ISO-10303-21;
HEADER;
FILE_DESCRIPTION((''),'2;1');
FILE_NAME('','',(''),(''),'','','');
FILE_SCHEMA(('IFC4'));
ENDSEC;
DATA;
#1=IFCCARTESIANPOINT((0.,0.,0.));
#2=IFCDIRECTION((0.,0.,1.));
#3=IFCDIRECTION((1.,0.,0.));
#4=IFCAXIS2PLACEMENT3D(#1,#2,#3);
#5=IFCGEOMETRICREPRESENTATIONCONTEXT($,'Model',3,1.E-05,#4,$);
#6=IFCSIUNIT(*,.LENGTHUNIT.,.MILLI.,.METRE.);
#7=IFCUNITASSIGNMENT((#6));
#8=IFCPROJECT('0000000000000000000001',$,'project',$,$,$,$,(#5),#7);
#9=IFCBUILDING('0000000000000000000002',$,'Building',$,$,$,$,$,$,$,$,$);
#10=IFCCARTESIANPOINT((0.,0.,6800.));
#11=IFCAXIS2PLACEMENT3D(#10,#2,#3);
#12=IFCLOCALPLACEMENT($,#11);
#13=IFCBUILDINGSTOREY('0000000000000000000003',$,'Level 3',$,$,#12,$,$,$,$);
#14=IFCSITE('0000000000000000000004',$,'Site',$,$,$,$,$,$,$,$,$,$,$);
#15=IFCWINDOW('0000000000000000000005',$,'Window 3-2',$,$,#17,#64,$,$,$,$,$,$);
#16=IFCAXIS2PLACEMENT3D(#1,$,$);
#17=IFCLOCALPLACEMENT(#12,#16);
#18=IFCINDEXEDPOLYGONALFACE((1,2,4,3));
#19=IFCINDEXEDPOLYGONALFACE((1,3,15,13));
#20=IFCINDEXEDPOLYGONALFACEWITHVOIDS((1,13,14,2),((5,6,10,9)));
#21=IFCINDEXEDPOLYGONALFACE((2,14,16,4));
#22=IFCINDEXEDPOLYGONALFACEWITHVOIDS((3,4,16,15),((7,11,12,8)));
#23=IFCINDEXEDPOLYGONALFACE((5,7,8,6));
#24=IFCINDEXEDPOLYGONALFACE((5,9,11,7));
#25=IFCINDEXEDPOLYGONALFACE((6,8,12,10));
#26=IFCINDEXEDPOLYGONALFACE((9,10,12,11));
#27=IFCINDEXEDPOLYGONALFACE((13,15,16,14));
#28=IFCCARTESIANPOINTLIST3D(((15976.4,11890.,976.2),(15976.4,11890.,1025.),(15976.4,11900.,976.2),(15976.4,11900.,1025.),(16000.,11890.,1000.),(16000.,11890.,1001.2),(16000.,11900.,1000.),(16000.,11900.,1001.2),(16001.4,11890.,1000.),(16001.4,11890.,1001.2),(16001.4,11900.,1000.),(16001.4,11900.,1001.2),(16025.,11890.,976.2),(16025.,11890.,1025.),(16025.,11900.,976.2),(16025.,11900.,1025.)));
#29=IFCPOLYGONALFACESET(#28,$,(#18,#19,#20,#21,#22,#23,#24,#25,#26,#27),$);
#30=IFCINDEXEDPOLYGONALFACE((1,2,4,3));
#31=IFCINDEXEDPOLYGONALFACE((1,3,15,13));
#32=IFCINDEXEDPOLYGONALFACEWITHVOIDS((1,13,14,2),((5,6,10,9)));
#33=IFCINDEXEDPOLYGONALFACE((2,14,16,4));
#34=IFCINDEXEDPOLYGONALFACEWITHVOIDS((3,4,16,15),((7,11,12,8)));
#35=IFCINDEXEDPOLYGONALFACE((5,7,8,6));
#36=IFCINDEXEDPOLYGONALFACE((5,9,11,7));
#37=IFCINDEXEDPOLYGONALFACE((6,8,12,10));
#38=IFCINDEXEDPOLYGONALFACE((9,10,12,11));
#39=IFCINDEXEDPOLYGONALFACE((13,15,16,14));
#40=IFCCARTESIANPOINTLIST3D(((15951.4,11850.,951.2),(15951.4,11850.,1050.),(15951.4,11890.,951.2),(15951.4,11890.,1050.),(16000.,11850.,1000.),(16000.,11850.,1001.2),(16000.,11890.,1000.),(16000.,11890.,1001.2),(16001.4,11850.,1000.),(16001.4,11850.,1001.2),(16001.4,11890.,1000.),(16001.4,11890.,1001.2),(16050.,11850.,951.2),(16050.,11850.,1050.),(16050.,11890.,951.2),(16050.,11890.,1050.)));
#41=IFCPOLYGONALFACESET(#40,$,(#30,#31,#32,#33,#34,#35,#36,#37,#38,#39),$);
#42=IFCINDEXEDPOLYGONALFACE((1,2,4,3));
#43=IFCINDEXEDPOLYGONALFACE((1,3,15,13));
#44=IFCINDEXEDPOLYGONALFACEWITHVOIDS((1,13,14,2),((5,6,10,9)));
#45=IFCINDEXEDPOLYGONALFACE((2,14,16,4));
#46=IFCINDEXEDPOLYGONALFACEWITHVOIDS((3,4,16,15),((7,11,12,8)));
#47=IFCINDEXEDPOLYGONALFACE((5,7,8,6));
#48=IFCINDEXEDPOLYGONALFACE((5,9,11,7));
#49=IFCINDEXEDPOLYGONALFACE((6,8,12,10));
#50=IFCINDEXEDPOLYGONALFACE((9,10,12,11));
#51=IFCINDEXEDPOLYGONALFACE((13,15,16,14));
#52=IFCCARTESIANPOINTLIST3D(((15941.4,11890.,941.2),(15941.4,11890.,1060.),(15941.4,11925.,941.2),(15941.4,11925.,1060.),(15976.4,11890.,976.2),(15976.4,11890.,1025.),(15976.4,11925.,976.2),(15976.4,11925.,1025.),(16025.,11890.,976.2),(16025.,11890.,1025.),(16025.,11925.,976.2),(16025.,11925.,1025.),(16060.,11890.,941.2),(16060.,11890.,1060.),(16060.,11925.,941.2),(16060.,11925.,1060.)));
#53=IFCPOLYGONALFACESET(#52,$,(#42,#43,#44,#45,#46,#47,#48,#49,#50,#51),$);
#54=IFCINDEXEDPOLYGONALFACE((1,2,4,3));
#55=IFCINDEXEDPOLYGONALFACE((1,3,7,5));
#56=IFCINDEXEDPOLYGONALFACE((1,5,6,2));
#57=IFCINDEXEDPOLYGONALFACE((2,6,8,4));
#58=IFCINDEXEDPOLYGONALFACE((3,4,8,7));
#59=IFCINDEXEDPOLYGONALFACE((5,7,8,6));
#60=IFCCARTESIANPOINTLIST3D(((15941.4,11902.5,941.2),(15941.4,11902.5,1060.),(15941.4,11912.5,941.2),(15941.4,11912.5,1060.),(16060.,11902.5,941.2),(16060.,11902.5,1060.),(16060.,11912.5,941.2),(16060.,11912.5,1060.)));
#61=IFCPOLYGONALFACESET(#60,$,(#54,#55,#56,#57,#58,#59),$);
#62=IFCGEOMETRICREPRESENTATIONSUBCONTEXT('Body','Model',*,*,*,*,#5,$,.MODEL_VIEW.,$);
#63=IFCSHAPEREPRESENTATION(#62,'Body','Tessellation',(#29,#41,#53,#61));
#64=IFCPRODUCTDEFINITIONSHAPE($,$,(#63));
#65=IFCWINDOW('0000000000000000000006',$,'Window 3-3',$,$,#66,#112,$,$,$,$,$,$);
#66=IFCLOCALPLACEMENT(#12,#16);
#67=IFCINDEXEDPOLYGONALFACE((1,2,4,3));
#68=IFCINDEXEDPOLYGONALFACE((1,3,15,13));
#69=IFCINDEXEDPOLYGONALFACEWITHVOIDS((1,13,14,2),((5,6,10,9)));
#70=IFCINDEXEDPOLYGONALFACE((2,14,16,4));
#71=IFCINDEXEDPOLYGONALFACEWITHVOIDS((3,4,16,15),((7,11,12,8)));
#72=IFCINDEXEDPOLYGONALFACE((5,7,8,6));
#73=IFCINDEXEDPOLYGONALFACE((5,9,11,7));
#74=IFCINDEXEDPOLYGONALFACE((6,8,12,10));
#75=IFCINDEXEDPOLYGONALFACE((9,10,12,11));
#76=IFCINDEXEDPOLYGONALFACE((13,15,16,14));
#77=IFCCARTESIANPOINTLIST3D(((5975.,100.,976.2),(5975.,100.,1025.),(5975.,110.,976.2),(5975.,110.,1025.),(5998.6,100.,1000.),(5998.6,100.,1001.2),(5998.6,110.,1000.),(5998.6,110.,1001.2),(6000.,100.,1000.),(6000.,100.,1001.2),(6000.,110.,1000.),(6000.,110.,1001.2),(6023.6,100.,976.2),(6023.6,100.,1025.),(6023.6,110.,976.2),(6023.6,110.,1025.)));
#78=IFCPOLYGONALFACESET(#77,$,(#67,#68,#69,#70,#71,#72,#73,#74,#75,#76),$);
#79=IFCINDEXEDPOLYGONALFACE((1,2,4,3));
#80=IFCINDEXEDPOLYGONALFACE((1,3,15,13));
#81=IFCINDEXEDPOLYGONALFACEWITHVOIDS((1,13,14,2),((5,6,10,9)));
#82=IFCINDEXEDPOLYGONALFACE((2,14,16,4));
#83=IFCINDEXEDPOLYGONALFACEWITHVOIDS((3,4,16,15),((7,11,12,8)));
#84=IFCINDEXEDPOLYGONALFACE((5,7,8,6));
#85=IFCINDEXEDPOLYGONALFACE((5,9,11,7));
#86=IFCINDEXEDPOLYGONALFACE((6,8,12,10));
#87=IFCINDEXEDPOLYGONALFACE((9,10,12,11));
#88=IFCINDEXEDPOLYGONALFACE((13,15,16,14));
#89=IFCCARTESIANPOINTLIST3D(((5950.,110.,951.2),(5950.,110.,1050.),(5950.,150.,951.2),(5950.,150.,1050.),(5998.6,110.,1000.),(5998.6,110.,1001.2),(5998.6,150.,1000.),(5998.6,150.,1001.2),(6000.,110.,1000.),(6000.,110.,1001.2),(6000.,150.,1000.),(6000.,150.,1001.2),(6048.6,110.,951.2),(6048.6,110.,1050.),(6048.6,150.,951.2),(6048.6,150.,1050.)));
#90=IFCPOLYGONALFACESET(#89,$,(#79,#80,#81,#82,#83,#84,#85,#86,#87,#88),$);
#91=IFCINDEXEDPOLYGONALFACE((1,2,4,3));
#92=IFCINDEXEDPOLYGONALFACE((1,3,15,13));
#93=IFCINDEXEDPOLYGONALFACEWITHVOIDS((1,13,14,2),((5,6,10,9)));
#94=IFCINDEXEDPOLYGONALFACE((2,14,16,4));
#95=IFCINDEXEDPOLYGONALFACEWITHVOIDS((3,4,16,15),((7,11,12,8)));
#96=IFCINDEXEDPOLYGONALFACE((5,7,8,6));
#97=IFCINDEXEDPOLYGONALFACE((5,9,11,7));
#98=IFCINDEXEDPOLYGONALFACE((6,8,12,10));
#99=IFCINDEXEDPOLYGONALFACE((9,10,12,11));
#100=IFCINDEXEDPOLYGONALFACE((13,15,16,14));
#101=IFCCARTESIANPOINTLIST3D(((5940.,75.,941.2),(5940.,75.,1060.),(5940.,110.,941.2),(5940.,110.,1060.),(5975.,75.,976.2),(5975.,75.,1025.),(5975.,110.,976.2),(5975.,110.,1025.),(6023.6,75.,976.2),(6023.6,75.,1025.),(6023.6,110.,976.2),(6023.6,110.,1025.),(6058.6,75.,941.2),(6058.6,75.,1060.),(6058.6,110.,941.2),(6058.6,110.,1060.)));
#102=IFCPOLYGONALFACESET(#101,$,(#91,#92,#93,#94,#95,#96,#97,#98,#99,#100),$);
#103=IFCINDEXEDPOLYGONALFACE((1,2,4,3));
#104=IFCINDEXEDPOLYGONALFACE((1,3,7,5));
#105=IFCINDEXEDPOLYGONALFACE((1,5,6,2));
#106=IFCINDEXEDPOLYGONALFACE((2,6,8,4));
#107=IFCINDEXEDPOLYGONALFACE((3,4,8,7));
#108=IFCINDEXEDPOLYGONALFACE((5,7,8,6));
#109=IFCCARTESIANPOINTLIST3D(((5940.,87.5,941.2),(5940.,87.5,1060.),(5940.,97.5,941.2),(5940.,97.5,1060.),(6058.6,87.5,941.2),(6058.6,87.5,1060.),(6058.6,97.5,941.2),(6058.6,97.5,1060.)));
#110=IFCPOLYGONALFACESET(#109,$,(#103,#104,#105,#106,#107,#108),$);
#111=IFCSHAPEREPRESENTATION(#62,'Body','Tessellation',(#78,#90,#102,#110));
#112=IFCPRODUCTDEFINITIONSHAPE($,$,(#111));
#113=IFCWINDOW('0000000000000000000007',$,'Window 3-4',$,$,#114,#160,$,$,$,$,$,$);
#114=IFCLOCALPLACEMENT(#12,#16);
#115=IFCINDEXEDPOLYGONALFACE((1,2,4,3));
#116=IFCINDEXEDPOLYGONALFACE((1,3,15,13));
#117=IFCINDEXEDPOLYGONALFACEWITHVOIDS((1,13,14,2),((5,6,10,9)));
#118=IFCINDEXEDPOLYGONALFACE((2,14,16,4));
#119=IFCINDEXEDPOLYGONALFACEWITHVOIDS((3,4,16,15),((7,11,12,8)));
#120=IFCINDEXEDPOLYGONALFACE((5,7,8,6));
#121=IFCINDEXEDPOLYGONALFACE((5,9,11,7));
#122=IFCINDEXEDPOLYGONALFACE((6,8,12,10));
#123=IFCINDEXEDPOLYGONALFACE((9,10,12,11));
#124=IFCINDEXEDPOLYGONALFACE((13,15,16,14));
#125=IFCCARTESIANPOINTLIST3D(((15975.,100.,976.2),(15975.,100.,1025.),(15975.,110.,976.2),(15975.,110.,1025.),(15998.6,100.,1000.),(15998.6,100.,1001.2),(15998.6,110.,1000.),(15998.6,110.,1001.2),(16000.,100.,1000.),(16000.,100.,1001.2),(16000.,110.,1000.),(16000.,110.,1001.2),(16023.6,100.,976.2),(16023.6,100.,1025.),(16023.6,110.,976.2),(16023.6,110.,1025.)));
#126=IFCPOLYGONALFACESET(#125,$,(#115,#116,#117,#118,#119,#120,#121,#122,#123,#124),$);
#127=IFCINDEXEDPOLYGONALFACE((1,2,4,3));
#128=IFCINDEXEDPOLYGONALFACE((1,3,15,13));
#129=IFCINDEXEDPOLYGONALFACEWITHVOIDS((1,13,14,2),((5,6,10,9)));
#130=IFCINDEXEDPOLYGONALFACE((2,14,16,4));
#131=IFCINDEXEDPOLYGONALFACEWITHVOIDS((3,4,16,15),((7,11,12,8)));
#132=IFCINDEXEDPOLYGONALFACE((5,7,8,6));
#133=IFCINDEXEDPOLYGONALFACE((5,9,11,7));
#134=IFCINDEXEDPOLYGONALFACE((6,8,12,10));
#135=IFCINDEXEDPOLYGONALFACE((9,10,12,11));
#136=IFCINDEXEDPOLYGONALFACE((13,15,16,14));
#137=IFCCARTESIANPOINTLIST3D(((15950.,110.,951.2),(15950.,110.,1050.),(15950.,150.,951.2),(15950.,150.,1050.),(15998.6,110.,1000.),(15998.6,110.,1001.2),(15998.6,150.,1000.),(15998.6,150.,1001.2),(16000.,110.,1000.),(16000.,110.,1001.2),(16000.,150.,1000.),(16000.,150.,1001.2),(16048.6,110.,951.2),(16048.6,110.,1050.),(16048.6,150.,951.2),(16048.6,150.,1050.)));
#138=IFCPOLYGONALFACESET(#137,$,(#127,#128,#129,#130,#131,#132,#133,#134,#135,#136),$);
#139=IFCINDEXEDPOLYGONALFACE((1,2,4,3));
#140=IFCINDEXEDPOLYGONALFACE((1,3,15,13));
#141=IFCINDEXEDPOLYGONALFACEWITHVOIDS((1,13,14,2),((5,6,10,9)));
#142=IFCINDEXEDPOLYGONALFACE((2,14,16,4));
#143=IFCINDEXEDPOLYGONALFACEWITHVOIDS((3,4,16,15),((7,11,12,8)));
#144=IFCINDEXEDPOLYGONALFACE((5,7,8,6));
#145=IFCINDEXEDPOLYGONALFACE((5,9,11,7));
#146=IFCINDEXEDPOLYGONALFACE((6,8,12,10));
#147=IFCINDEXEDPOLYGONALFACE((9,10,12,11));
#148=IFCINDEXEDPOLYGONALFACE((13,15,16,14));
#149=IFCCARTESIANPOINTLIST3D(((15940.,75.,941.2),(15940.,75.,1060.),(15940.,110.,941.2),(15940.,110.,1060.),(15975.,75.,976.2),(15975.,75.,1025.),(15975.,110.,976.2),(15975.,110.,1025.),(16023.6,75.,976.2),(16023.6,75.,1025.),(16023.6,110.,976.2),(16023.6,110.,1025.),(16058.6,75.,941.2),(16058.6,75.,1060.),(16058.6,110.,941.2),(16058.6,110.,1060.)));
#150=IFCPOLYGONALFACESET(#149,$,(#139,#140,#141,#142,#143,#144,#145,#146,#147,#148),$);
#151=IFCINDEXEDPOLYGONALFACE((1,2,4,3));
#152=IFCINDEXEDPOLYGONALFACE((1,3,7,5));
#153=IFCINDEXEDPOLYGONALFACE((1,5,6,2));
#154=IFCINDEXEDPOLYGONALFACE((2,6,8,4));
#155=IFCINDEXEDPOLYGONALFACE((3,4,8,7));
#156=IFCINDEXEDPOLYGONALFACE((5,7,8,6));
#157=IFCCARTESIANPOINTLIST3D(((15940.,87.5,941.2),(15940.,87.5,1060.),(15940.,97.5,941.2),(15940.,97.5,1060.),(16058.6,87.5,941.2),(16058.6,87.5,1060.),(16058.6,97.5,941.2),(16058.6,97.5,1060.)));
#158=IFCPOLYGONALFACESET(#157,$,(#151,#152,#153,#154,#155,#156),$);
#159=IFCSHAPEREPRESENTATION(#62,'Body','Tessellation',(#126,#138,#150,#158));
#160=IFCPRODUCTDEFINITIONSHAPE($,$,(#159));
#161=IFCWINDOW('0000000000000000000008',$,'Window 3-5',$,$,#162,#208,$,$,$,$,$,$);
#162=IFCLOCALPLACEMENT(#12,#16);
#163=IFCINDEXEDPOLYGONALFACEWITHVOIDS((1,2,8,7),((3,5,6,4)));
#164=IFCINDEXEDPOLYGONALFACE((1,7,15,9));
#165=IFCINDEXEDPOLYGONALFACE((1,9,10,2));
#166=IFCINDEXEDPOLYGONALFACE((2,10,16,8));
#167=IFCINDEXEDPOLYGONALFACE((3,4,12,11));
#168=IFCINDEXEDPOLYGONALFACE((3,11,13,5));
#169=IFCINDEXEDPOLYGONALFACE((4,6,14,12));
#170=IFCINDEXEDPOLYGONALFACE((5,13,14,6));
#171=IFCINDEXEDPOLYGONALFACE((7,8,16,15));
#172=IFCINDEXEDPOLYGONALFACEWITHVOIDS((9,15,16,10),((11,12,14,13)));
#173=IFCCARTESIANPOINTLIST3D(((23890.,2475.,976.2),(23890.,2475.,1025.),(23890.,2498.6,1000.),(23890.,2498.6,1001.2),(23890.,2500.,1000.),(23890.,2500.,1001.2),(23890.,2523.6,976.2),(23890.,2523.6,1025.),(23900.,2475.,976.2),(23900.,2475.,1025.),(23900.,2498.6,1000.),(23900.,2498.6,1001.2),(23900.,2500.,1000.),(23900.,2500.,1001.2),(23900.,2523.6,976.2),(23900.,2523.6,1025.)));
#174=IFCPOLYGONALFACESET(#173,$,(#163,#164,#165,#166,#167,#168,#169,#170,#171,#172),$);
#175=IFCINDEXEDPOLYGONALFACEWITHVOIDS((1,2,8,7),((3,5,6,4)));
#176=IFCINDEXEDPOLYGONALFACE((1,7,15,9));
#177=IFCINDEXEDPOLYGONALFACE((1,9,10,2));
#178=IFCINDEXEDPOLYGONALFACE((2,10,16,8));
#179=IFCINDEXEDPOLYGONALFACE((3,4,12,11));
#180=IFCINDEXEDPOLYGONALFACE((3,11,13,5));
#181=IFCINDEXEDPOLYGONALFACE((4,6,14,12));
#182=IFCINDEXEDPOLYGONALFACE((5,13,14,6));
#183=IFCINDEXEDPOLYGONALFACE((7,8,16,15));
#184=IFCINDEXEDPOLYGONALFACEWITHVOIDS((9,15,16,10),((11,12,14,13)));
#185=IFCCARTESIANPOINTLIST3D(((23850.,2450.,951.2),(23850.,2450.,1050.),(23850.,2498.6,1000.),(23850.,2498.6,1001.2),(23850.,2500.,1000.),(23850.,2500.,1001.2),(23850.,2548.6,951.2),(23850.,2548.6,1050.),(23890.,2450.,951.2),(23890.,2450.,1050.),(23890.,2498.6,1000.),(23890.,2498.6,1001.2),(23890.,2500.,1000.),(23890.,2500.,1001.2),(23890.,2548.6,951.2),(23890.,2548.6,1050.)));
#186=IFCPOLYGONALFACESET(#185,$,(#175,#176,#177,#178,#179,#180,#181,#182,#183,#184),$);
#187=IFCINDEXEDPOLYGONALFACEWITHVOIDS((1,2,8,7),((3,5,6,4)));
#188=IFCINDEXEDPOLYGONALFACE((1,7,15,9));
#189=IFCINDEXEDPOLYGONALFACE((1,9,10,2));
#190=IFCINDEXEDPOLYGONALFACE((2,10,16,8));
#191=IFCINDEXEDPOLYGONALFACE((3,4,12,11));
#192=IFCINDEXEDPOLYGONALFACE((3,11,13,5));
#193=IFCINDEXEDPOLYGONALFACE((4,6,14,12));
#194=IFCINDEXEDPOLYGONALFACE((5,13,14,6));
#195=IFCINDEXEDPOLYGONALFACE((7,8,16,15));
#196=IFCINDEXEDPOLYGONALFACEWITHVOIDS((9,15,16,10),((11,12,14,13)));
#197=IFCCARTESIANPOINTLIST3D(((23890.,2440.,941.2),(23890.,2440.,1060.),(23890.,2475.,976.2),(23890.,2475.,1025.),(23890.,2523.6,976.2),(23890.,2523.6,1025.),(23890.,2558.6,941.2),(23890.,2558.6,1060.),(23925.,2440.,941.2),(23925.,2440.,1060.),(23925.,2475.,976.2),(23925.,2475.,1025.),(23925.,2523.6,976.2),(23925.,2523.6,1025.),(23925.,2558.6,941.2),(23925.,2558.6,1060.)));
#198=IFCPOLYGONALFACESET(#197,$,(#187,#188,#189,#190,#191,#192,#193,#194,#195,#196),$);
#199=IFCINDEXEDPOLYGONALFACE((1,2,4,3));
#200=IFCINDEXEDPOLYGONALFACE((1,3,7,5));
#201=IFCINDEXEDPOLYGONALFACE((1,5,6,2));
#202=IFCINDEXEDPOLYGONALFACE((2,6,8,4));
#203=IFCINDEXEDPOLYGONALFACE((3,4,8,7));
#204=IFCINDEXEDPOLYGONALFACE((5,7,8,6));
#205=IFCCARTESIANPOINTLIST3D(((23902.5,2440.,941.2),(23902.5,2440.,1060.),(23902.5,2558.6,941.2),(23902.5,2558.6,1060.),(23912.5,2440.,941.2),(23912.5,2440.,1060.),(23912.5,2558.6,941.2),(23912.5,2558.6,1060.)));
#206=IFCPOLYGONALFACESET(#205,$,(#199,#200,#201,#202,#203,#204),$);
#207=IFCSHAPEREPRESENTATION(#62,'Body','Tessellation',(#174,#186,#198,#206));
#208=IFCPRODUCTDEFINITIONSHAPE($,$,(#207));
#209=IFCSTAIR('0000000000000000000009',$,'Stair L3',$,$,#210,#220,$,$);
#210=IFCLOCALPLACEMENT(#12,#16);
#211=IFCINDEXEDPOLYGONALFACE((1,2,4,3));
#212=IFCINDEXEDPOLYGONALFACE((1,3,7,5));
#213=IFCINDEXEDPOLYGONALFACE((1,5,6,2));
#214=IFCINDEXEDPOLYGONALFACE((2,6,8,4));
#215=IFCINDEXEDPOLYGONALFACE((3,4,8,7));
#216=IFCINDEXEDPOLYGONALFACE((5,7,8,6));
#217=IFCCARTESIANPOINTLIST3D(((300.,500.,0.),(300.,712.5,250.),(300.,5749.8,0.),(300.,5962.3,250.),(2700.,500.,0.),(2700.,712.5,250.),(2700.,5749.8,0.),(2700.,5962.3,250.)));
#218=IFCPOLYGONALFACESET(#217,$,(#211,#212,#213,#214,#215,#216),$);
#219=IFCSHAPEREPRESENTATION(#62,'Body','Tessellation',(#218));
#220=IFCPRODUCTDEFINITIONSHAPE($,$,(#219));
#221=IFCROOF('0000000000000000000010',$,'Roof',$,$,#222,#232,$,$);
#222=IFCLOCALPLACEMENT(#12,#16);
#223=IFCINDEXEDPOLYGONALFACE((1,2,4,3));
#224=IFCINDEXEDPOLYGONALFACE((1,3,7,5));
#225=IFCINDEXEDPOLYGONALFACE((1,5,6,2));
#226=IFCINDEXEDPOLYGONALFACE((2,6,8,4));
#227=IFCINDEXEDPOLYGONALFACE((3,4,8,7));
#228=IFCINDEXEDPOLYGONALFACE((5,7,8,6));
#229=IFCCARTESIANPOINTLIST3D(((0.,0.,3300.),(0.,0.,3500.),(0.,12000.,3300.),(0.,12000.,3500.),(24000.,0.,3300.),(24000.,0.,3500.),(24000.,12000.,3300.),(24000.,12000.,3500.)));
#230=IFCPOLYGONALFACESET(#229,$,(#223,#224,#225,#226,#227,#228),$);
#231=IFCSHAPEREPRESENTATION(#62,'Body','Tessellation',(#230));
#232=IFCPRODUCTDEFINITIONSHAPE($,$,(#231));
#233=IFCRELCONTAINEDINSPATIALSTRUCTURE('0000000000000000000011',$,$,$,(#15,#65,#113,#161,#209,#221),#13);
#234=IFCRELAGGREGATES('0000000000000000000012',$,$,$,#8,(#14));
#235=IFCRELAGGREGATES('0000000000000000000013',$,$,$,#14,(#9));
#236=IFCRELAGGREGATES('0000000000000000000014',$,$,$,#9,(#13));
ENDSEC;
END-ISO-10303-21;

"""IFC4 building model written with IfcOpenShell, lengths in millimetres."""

from ifc_helpers import new_model, si_unit, frame, origin_with_axes, place, context, subcontext, project, spatial, line, indexed_curve, outline, extrude, element, save


model = new_model("IFC4")

# Units and contexts
model_context = context("Model", 3, precision=1e-05, world=origin_with_axes())
body_context = subcontext(model_context, "Body", "Model", "MODEL_VIEW")
ifc_project = project(units=[si_unit("LENGTHUNIT", "METRE", prefix="MILLI")], contexts=[model_context])

# Site, building, storey
site = spatial("IfcSite", under=ifc_project, Name="Site")
building = spatial("IfcBuilding", under=site, Name="Building")
storey_placement = place(None, frame((0.0, 0.0, 6800.0), z_axis=(0.0, 0.0, 1.0), x_axis=(1.0, 0.0, 0.0)))
storey = spatial("IfcBuildingStorey", under=building, at=storey_placement, Name="Level 3")

# Windows
for number, where, z_axis, x_axis, name in (
    (1, (16000.0, 11800.0, 1000.0), (0.0, 0.0, 1.0), (1.0, 0.0, 0.0), "Window 3-2"),
    (2, (6000.0, 200.0, 1000.0), (0.0, 0.0, 1.0), (-1.0, 0.0, 0.0), "Window 3-3"),
    (3, (16000.0, 200.0, 1000.0), (0.0, 0.0, 1.0), (-1.0, 0.0, 0.0), "Window 3-4"),
    (4, (23800.0, 2500.0, 1000.0), (0.0, 0.0, 1.0), (0.0, -1.0, 0.0), "Window 3-5"),
):
    element("IfcWindow", number, at=place(storey_placement, frame(where, z_axis=z_axis, x_axis=x_axis)), inside=storey, Name=name, context=body_context, shape_type="SweptSolid", body=[
        extrude(outline(indexed_curve([(0.0, 0.0), (1.4, 0.0), (1.4, 1.2), (0.0, 1.2)], segments=[line(1, 2, 3, 4, 1)]), holes=[indexed_curve([(25.0, 25.0), (-23.6, 25.0), (-23.6, -23.8), (25.0, -23.8)], segments=[line(1, 2, 3, 4, 1)])]), frame((0.0, 90.0, 0.0), z_axis=(0.0, -1.0, 0.0), x_axis=(1.0, 0.0, 0.0)), (0.0, 0.0, -1.0), 10.0),
        extrude(outline(indexed_curve([(0.0, 0.0), (1.4, 0.0), (1.4, 1.2), (0.0, 1.2)], segments=[line(1, 2, 3, 4, 1)]), holes=[indexed_curve([(50.0, 50.0), (-48.6, 50.0), (-48.6, -48.8), (50.0, -48.8)], segments=[line(1, 2, 3, 4, 1)])]), frame((0.0, 50.0, 0.0), z_axis=(0.0, -1.0, 0.0), x_axis=(1.0, 0.0, 0.0)), (0.0, 0.0, -1.0), 40.0),
        extrude(outline(indexed_curve([(0.0, 0.0), (-48.6, 0.0), (-48.6, -48.8), (0.0, -48.8)], segments=[line(1, 2, 3, 4, 1)]), holes=[indexed_curve([(35.0, 35.0), (-83.6, 35.0), (-83.6, -83.8), (35.0, -83.8)], segments=[line(1, 2, 3, 4, 1)])]), frame((25.0, 90.0, 25.0), z_axis=(0.0, -1.0, 0.0), x_axis=(1.0, 0.0, 0.0)), (0.0, 0.0, -1.0), 35.0),
        extrude(outline(indexed_curve([(35.0, 35.0), (-83.6, 35.0), (-83.6, -83.8), (35.0, -83.8)], segments=[line(1, 2, 3, 4, 1)])), frame((25.0, 102.5, 25.0), z_axis=(0.0, -1.0, 0.0), x_axis=(1.0, 0.0, 0.0)), (0.0, 0.0, -1.0), 10.0),
    ])

# Stair
stair_placement = place(storey_placement, frame((300.0, 500.0, 0.0), z_axis=(0.0, 0.0, 1.0), x_axis=(1.0, 0.0, 0.0)))
element("IfcStair", 5, at=stair_placement, inside=storey, Name="Stair L3", context=body_context, shape_type="SweptSolid", body=[
    extrude(outline(indexed_curve([(0.0, 0.0), (2400.0, 0.0), (2400.0, 5249.8), (0.0, 5249.8), (0.0, 0.0)])), None, (0.0, 0.647648, 0.761939), 328.1),
])

# Roof
roof_placement = place(storey_placement, frame((0.0, 0.0, 3300.0), z_axis=(0.0, 0.0, 1.0), x_axis=(1.0, 0.0, 0.0)))
element("IfcRoof", 6, at=roof_placement, inside=storey, Name="Roof", context=body_context, shape_type="SweptSolid", body=[
    extrude(outline(indexed_curve([(0.0, 0.0), (24000.0, 0.0), (24000.0, 12000.0), (0.0, 12000.0), (0.0, 0.0)])), None, (0.0, 0.0, 1.0), 200.0),
])

save(model, "model.ifc")
